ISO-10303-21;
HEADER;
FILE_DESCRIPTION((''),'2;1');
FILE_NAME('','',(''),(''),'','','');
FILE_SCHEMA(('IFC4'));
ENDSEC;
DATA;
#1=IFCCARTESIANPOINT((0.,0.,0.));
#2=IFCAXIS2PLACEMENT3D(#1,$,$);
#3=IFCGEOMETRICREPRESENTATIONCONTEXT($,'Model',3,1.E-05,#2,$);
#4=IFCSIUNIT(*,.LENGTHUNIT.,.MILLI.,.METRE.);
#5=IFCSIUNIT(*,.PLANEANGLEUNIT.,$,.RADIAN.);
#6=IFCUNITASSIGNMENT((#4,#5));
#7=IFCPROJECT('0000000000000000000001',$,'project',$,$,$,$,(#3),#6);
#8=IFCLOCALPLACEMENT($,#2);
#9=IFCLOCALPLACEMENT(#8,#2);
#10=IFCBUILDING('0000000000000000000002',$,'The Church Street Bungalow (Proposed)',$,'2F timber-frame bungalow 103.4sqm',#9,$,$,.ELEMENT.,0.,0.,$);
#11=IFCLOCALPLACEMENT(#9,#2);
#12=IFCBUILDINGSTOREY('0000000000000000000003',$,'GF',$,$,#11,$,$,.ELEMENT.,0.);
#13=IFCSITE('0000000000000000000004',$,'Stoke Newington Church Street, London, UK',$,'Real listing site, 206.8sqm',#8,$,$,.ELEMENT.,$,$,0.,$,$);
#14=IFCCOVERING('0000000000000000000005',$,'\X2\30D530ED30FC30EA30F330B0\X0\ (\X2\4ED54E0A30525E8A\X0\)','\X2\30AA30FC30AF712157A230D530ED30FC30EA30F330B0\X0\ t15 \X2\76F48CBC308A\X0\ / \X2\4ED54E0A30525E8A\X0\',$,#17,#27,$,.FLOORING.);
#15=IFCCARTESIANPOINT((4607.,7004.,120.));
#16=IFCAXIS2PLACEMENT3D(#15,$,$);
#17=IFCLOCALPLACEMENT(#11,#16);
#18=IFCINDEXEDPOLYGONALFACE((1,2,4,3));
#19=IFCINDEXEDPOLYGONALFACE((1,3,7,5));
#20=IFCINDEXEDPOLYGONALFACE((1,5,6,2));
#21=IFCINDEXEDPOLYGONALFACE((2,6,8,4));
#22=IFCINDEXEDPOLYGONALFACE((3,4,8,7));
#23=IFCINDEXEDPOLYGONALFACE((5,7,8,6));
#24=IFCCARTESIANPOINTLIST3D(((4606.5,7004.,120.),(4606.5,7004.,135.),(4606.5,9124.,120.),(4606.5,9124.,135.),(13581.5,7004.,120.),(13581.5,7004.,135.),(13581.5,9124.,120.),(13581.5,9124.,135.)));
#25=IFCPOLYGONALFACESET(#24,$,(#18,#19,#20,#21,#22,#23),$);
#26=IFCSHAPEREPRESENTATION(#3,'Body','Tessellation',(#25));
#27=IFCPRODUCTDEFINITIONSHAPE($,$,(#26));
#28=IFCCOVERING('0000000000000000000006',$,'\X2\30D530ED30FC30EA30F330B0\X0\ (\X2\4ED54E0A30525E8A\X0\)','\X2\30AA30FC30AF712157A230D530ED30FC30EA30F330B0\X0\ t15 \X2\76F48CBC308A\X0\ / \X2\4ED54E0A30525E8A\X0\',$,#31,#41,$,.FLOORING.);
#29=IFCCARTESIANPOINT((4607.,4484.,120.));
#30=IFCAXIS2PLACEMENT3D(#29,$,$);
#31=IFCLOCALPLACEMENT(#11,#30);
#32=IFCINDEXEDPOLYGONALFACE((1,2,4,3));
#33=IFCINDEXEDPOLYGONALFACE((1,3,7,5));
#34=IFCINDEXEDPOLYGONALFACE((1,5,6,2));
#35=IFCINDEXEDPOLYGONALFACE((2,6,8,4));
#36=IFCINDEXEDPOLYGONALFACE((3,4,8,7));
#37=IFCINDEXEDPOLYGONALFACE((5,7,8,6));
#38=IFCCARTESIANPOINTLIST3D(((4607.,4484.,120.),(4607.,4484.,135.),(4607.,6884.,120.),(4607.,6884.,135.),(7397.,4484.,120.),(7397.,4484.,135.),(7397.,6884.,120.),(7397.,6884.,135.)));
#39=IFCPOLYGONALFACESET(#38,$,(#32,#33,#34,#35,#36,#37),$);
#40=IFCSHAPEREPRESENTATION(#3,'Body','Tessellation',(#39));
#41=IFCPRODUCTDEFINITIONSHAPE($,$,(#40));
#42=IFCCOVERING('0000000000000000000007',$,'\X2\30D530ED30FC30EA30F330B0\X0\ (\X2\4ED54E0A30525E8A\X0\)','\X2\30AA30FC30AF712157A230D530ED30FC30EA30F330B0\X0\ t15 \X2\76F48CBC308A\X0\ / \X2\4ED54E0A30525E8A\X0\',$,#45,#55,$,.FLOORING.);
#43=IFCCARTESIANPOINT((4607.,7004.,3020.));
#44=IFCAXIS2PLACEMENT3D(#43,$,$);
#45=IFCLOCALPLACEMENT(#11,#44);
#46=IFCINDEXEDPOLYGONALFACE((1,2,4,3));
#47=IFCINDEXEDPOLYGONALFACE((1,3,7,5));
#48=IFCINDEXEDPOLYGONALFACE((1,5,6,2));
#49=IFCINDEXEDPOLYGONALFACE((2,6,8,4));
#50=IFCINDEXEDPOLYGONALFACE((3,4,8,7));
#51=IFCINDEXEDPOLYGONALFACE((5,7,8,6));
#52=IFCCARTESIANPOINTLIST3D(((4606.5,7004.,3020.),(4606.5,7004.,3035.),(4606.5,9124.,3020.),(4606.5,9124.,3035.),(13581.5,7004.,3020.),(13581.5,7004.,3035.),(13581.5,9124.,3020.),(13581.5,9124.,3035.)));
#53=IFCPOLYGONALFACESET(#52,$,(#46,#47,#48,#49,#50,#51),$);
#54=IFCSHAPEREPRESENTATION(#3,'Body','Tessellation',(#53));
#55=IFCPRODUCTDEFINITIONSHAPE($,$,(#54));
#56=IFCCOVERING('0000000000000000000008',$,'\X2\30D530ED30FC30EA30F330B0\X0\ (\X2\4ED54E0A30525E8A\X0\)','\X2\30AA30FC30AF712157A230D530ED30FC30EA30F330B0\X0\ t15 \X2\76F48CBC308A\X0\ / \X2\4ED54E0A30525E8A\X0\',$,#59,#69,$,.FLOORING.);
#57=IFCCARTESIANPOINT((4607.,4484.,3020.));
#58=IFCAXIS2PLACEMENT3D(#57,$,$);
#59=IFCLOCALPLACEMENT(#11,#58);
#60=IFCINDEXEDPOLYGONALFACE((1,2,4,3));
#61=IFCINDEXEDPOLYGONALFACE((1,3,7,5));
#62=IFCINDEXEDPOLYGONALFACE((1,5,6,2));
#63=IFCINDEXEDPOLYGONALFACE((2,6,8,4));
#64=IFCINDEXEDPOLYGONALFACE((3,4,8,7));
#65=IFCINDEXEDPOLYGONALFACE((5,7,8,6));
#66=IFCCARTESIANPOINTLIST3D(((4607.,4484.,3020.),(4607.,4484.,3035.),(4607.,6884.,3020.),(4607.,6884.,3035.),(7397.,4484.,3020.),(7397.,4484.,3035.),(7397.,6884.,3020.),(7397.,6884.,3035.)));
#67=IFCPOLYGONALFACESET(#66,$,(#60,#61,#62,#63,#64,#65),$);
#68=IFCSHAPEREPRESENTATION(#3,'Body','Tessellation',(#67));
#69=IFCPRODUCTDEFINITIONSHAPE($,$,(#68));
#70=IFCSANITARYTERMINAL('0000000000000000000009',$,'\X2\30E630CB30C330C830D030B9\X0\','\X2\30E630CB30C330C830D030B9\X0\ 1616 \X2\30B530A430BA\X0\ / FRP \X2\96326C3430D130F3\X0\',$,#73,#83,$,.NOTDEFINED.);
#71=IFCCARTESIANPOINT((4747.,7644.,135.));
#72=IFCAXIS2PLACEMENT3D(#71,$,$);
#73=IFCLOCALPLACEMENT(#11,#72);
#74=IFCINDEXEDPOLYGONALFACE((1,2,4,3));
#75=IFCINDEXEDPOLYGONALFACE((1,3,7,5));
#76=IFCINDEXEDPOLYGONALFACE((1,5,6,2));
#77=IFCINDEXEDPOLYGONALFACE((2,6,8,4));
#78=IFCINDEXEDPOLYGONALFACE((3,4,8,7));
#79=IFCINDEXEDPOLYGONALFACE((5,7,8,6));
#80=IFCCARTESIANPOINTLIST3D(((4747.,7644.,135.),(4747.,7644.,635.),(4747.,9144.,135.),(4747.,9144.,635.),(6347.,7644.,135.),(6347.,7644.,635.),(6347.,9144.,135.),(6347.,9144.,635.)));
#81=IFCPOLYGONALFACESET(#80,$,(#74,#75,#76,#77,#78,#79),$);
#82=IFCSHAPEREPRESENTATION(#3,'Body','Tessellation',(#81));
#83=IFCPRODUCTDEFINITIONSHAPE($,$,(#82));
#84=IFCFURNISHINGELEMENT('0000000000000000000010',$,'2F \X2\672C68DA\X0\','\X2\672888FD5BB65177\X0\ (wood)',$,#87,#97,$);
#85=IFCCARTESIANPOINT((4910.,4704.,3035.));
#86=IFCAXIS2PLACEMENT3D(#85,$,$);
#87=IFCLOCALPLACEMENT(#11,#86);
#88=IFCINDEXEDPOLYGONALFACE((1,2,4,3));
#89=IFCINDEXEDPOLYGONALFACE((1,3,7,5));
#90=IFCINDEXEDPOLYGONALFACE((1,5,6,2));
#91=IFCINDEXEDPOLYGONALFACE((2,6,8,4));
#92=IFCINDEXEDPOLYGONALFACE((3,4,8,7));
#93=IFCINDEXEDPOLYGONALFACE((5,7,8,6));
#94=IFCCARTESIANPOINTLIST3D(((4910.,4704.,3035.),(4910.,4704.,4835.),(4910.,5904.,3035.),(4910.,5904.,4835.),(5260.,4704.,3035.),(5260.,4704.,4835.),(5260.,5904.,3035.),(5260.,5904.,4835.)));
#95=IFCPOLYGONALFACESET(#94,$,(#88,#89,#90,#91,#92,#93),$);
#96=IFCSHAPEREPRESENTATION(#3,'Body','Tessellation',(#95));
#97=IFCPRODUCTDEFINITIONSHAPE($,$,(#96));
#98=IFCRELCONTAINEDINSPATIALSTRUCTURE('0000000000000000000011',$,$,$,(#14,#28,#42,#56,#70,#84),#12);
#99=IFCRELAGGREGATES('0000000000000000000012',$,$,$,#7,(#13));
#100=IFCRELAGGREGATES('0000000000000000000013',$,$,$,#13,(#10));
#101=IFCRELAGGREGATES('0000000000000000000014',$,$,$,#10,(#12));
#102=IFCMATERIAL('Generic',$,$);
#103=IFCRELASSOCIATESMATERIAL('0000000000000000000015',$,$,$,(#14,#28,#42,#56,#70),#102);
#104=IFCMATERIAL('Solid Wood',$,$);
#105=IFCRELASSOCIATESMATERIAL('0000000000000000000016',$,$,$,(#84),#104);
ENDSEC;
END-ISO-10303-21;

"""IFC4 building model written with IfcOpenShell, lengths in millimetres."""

from ifc_helpers import new_model, si_unit, frame, frame_2d, origin, place, context, project, spatial, rectangle, extrude, material, element, save


model = new_model("IFC4")

# Units and contexts
model_context = context("Model", 3, precision=1e-05, world=origin())
ifc_project = project(units=[si_unit("LENGTHUNIT", "METRE", prefix="MILLI"), si_unit("PLANEANGLEUNIT", "RADIAN")], contexts=[model_context])

# Site, building, storey
site_placement = place(None, origin())
site = spatial("IfcSite", under=ifc_project, at=site_placement, Name="Stoke Newington Church Street, London, UK", ObjectType="Real listing site, 206.8sqm", CompositionType="ELEMENT", RefElevation=0.0)
building_placement = place(site_placement, origin())
building = spatial("IfcBuilding", under=site, at=building_placement, Name="The Church Street Bungalow (Proposed)", ObjectType="2F timber-frame bungalow 103.4sqm", CompositionType="ELEMENT", ElevationOfRefHeight=0.0, ElevationOfTerrain=0.0)
storey_placement = place(building_placement, origin())
storey = spatial("IfcBuildingStorey", under=building, at=storey_placement, Name="GF", CompositionType="ELEMENT", Elevation=0.0)

# Shared definitions
ifc_material_1 = material(Name="Solid Wood")

# Coverings
ifc_material_2 = material(Name="Generic")
covering_1_placement = place(storey_placement, frame((4607.0, 7004.0, 120.0)))
element("IfcCovering", 1, at=covering_1_placement, inside=storey, material=ifc_material_2, Name="フローリング (仕上げ床)", Description="オーク無垢フローリング t15 直貼り / 仕上げ床", PredefinedType="FLOORING", context=model_context, shape_type="SweptSolid", body=[
    extrude(rectangle(XDim=8975.0, YDim=2120.0, at=frame_2d((4487.0, 1060.0))), frame((4607.0, 7004.0, 120.0)), (0.0, 0.0, 1.0), 15.0),
])
covering_2_placement = place(storey_placement, frame((4607.0, 4484.0, 120.0)))
element("IfcCovering", 2, at=covering_2_placement, inside=storey, material=ifc_material_2, Name="フローリング (仕上げ床)", Description="オーク無垢フローリング t15 直貼り / 仕上げ床", PredefinedType="FLOORING", context=model_context, shape_type="SweptSolid", body=[
    extrude(rectangle(XDim=2790.0, YDim=2400.0, at=frame_2d((1395.0, 1200.0))), frame((4607.0, 4484.0, 120.0)), (0.0, 0.0, 1.0), 15.0),
])
covering_3_placement = place(storey_placement, frame((4607.0, 7004.0, 3020.0)))
element("IfcCovering", 3, at=covering_3_placement, inside=storey, material=ifc_material_2, Name="フローリング (仕上げ床)", Description="オーク無垢フローリング t15 直貼り / 仕上げ床", PredefinedType="FLOORING", context=model_context, shape_type="SweptSolid", body=[
    extrude(rectangle(XDim=8975.0, YDim=2120.0, at=frame_2d((4487.0, 1060.0))), frame((4607.0, 7004.0, 3020.0)), (0.0, 0.0, 1.0), 15.0),
])
covering_4_placement = place(storey_placement, frame((4607.0, 4484.0, 3020.0)))
element("IfcCovering", 4, at=covering_4_placement, inside=storey, material=ifc_material_2, Name="フローリング (仕上げ床)", Description="オーク無垢フローリング t15 直貼り / 仕上げ床", PredefinedType="FLOORING", context=model_context, shape_type="SweptSolid", body=[
    extrude(rectangle(XDim=2790.0, YDim=2400.0, at=frame_2d((1395.0, 1200.0))), frame((4607.0, 4484.0, 3020.0)), (0.0, 0.0, 1.0), 15.0),
])

# Sanitary terminal
sanitary_terminal_placement = place(storey_placement, frame((4747.0, 7644.0, 135.0)))
element("IfcSanitaryTerminal", 5, at=sanitary_terminal_placement, inside=storey, material=ifc_material_2, Name="ユニットバス", Description="ユニットバス 1616 サイズ / FRP 防水パン", PredefinedType="NOTDEFINED", context=model_context, shape_type="SweptSolid", body=[
    extrude(rectangle(XDim=1600.0, YDim=1500.0, at=frame_2d((800.0, 750.0))), frame((4747.0, 7644.0, 135.0)), (0.0, 0.0, 1.0), 500.0),
])

# Furnishing element
furnishing_placement = place(storey_placement, frame((4910.0, 4704.0, 3035.0)))
element("IfcFurnishingElement", 6, at=furnishing_placement, inside=storey, material=ifc_material_1, Name="2F 本棚", Description="木製家具 (wood)", context=model_context, shape_type="SweptSolid", body=[
    extrude(rectangle(XDim=350.0, YDim=1200.0, at=frame_2d((175.0, 600.0))), frame((4910.0, 4704.0, 3035.0)), (0.0, 0.0, 1.0), 1800.0),
])

save(model, "model.ifc")
